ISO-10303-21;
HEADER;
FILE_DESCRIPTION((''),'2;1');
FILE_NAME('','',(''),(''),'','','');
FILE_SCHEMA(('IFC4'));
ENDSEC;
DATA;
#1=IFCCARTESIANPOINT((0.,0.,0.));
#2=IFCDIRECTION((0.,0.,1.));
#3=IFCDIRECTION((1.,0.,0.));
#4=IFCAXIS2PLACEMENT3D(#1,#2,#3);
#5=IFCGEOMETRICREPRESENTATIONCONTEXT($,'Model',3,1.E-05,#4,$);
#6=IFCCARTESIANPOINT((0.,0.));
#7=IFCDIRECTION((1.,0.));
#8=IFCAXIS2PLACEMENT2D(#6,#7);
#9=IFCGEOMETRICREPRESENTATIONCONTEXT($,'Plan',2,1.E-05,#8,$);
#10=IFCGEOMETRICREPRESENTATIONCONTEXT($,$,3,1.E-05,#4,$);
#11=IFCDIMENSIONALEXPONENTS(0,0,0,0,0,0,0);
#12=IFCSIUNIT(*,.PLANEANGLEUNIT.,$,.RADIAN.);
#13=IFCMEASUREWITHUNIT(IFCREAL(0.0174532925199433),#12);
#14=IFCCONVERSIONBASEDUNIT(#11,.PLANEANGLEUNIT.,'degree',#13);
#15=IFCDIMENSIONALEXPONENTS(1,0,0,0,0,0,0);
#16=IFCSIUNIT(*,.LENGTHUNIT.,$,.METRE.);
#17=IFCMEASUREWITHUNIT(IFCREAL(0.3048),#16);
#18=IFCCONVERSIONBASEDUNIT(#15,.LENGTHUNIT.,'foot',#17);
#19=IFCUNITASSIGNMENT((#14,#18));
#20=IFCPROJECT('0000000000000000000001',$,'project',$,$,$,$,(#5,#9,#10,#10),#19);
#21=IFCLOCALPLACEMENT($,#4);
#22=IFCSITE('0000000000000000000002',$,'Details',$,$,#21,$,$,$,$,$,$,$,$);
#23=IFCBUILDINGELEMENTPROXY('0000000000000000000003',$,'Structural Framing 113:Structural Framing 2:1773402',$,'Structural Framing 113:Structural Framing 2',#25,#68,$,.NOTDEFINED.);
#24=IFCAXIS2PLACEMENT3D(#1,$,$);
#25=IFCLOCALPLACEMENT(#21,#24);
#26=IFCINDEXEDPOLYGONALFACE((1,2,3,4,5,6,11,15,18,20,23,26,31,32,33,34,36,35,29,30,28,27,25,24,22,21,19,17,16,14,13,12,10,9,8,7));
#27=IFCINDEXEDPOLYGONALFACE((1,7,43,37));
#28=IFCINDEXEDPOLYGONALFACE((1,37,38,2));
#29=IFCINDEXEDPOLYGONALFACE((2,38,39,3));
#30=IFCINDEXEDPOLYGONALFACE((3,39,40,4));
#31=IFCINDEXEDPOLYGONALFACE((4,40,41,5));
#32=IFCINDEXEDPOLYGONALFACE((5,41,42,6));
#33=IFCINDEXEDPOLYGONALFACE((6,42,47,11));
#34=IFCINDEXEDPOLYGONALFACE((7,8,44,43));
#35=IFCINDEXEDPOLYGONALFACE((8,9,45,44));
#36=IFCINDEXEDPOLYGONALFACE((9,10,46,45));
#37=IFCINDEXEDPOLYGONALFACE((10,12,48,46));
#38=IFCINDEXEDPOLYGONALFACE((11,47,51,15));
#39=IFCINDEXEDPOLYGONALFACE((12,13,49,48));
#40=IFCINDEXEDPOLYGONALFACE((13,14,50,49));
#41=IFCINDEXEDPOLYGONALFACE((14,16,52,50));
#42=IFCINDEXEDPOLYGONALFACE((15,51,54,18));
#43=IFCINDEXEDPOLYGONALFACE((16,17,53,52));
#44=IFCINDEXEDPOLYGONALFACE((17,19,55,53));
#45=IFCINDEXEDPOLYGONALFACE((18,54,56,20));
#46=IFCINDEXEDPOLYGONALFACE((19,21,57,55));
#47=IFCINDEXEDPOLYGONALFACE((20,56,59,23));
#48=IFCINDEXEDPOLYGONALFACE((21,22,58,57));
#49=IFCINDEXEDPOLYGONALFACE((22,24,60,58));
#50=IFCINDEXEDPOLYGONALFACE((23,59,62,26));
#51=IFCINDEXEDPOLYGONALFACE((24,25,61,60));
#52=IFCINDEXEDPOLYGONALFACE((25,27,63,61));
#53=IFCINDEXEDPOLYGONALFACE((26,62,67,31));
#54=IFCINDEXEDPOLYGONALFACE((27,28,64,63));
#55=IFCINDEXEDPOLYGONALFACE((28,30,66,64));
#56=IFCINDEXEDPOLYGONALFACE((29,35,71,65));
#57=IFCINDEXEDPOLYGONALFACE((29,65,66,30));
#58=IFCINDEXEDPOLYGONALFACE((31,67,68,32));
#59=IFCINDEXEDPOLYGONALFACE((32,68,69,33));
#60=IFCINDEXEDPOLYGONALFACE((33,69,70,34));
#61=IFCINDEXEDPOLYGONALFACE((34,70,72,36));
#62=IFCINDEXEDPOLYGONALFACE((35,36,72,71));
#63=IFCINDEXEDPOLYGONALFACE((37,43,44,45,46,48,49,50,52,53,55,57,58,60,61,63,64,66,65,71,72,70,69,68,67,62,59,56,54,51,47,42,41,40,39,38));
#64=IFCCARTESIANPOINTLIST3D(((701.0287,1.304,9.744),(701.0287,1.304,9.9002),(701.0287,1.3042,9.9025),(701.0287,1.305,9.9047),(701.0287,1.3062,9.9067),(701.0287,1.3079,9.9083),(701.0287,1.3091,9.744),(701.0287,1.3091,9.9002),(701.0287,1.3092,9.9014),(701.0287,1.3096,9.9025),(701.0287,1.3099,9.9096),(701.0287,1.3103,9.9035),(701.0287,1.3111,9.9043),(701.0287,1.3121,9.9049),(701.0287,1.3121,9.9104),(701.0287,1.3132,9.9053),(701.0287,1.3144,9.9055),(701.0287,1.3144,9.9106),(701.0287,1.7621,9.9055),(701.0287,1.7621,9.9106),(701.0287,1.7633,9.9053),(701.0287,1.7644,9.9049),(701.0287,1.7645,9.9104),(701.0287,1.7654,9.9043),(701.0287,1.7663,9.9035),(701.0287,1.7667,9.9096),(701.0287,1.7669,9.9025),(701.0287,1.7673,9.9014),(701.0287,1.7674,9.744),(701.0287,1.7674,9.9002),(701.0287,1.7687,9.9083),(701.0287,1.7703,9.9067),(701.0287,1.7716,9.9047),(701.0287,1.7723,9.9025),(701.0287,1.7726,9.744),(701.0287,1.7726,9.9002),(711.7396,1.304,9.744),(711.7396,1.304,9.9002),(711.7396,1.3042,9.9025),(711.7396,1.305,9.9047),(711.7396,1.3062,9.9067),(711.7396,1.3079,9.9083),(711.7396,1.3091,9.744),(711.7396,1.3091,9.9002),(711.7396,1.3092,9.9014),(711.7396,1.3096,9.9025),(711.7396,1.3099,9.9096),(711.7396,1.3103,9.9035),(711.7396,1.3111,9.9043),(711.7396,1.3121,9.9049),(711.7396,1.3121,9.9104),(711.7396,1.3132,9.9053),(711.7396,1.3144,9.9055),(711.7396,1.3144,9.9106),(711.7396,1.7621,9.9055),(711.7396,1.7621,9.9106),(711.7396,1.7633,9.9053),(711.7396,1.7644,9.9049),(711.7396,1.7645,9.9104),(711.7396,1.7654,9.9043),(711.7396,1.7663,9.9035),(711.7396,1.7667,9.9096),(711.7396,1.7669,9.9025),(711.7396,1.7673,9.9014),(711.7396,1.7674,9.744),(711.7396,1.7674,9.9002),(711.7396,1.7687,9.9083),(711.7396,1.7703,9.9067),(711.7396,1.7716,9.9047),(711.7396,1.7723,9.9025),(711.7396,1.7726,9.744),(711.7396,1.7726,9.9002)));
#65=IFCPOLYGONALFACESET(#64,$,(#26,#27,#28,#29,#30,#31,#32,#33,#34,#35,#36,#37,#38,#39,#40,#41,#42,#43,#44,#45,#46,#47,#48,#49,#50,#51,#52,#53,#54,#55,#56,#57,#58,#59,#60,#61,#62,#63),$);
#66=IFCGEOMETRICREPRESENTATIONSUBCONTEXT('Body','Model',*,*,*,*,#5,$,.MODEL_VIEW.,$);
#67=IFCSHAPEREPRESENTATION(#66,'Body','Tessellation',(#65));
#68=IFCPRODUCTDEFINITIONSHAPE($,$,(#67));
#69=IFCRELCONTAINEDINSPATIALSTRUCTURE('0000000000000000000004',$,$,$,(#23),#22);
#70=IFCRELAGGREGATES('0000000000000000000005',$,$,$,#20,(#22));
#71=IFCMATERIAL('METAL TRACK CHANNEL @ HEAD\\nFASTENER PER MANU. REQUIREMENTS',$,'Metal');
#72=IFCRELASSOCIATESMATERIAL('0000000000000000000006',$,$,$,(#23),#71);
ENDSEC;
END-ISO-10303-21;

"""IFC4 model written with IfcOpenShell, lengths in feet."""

from ifc_helpers import new_model, entity, si_unit, converted_unit, frame, origin_with_axes, origin_2d_with_axis, place, context, subcontext, project, spatial, polyline, outline, extrude, material, element, save


model = new_model("IFC4")

# Units and contexts
model_context = context("Model", 3, precision=1e-05, world=origin_with_axes())
plan_context = context("Plan", 2, precision=1e-05, world=origin_2d_with_axis())
context_of_model = context(None, 3, precision=1e-05, world=origin_with_axes())
body_context = subcontext(model_context, "Body", "Model", "MODEL_VIEW")
ifc_project = project(units=[converted_unit("PLANEANGLEUNIT", "degree", entity("IfcReal", 0.0174532925199433), si_unit("PLANEANGLEUNIT", "RADIAN"), dimensions=[0, 0, 0, 0, 0, 0, 0]), converted_unit("LENGTHUNIT", "foot", entity("IfcReal", 0.3048), si_unit("LENGTHUNIT", "METRE"), dimensions=[1, 0, 0, 0, 0, 0, 0])], contexts=[model_context, plan_context, context_of_model, context_of_model])

# Site
site_placement = place(None, origin_with_axes())
site = spatial("IfcSite", under=ifc_project, at=site_placement, Name="Details")

# Building element proxy
ifc_material_1 = material(Name="METAL TRACK CHANNEL @ HEAD\\nFASTENER PER MANU. REQUIREMENTS", Category="Metal")
proxy_1_placement = place(site_placement, frame((706.3842, 1.5383, 9.8737), z_axis=(1.0, 0.0, 0.0), x_axis=(0.0, 0.0, -1.0)))
element("IfcBuildingElementProxy", 1, at=proxy_1_placement, inside=site, material=ifc_material_1, Name="Structural Framing 113:Structural Framing 2:1773402", ObjectType="Structural Framing 113:Structural Framing 2", PredefinedType="NOTDEFINED", context=body_context, shape_type="SweptSolid", body=[
    extrude(outline(polyline([(0.2295, 0.0), (0.2295, -0.0012), (0.2291, -0.0023), (0.2286, -0.0034), (0.2278, -0.0042), (0.2268, -0.0049), (0.2257, -0.0054), (0.2246, -0.0056), (-0.2225, -0.031), (-0.2237, -0.031), (-0.2248, -0.0306), (-0.2258, -0.0301), (-0.2267, -0.0293), (-0.2274, -0.0283), (-0.2279, -0.0272), (-0.2281, -0.026), (-0.2369, 0.1299), (-0.2421, 0.1296), (-0.2332, -0.0263), (-0.2328, -0.0286), (-0.2319, -0.0308), (-0.2306, -0.0327), (-0.2288, -0.0343), (-0.2268, -0.0354), (-0.2245, -0.036), (-0.2222, -0.0362), (0.2248, -0.0107), (0.2272, -0.0103), (0.2293, -0.0094), (0.2312, -0.0081), (0.2328, -0.0063), (0.2339, -0.0043), (0.2346, -0.002), (0.2347, 0.0003), (0.2258, 0.1563), (0.2207, 0.156), (0.2295, 0.0)])), frame((-0.0134, 0.0, -5.3554), z_axis=(-0.000089, 0.0, -1.0), x_axis=(-0.056806, 0.998385, 0.000005)), (0.000005, -0.000088, -1.0), 10.7109),
])

save(model, "model.ifc")
